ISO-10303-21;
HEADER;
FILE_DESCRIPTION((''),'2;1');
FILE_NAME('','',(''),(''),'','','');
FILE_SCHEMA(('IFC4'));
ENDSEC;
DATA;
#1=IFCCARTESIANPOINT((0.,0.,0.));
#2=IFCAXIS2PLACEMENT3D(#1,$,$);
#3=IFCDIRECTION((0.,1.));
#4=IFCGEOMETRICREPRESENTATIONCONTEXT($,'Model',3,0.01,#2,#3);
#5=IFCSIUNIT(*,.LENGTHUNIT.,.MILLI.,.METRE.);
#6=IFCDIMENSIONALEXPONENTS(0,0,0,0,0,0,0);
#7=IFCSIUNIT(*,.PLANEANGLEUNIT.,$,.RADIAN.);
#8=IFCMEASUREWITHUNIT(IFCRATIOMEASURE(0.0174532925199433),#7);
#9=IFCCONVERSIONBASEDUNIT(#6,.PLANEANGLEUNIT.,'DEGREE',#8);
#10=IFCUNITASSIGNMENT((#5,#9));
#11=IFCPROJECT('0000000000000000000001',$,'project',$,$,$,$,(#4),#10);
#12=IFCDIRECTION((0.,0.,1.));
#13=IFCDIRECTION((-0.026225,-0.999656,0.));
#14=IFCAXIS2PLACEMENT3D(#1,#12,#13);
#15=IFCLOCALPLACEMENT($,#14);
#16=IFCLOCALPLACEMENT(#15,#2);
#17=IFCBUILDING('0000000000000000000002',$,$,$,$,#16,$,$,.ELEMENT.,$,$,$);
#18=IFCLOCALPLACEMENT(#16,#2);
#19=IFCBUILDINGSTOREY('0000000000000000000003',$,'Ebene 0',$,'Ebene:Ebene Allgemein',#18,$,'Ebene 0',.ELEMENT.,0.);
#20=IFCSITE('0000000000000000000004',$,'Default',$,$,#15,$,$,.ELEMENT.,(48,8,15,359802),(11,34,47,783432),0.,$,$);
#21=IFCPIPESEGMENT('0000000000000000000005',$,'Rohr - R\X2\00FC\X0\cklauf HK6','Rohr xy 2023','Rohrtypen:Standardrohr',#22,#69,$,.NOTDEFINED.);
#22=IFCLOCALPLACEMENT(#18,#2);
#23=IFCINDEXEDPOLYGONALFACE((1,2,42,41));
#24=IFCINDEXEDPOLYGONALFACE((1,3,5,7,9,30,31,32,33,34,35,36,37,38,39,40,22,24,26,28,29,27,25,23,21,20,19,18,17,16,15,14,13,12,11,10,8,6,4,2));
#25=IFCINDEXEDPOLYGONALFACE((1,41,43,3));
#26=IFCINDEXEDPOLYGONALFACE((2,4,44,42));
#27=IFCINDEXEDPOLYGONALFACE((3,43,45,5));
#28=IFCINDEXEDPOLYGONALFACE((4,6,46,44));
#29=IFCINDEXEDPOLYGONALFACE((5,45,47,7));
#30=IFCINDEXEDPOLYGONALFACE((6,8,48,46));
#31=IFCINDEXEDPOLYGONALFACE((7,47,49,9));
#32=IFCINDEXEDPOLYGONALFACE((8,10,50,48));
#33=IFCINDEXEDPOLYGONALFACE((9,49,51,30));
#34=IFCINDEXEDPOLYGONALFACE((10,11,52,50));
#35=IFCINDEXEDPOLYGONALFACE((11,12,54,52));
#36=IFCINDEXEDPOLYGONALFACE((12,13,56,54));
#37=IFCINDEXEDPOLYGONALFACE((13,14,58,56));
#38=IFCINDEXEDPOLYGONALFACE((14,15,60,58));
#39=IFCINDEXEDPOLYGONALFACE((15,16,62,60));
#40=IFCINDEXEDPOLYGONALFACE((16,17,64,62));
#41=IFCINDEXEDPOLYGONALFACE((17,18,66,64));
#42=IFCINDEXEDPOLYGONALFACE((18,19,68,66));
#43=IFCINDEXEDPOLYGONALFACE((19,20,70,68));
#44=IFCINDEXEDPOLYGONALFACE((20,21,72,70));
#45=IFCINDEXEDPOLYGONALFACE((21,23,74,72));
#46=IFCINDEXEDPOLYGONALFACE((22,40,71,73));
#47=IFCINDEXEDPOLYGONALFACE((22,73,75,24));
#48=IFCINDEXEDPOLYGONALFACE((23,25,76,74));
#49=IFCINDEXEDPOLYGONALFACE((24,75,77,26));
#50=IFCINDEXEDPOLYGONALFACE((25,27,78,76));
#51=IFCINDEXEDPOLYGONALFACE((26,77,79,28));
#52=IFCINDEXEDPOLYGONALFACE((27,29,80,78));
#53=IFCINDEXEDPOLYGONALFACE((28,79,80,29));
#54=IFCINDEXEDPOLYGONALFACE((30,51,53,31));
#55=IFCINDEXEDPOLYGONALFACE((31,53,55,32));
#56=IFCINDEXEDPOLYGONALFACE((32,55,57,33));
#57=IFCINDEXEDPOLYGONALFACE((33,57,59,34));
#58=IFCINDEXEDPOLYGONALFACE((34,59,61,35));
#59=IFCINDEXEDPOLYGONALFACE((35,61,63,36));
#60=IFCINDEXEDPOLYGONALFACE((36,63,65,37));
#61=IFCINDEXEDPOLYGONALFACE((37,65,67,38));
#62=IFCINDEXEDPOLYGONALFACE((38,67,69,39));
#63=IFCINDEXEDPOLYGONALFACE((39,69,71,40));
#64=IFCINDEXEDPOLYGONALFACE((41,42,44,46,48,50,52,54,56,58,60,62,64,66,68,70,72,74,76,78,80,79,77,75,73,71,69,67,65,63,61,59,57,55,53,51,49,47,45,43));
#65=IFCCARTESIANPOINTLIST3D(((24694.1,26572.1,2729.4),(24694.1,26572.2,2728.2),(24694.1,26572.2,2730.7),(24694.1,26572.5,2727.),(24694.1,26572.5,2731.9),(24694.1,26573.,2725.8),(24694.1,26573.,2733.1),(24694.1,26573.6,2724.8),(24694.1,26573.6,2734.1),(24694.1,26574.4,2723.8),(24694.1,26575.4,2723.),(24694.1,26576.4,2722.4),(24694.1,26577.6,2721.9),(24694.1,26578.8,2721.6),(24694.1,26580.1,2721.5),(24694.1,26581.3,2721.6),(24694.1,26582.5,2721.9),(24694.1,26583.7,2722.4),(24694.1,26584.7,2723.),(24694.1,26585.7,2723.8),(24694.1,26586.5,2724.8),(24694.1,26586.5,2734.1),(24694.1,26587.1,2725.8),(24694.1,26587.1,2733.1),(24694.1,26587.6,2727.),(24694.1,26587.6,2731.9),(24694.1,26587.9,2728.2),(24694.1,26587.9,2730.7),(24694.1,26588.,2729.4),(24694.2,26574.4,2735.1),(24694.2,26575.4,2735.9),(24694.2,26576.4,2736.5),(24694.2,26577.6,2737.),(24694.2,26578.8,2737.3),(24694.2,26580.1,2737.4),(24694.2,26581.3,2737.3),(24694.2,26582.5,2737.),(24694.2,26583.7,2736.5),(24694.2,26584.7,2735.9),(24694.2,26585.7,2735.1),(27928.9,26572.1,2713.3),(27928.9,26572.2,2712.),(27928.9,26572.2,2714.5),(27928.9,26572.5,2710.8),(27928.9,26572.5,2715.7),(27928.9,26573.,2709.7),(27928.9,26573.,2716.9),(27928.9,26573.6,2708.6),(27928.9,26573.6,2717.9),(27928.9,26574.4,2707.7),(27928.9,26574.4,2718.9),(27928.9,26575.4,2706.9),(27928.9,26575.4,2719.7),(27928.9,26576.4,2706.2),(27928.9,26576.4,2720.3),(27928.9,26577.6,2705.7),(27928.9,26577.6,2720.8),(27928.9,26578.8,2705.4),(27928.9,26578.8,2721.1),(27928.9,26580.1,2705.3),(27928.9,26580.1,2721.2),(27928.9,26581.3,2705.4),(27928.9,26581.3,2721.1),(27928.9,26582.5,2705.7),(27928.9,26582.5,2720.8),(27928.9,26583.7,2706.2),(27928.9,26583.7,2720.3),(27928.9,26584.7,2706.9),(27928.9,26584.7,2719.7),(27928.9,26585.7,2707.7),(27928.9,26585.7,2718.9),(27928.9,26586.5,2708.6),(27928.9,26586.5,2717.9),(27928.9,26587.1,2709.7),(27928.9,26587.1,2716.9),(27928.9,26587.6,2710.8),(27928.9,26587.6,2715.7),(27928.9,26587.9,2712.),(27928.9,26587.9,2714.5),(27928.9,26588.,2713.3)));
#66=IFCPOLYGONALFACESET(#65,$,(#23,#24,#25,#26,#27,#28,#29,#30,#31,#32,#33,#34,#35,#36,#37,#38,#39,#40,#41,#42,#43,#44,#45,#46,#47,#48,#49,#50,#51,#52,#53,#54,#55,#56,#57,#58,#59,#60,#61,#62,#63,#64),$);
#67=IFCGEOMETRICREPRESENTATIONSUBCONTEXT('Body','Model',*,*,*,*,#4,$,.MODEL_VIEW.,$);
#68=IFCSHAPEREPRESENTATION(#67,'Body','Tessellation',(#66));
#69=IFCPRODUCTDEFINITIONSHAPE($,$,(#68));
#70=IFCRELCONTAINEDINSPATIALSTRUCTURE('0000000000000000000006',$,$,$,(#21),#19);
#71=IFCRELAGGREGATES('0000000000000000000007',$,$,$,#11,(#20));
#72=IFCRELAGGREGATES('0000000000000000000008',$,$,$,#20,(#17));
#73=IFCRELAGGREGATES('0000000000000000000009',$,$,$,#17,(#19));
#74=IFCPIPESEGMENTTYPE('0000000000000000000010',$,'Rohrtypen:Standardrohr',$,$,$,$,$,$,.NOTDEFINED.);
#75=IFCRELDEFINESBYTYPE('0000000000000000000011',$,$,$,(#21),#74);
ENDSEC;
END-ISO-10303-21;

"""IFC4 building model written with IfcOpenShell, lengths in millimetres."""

from ifc_helpers import new_model, entity, si_unit, converted_unit, direction, frame, origin, place, context, subcontext, project, spatial, indexed_curve, outline, extrude, type_object, element, save


model = new_model("IFC4")

# Units and contexts
model_context = context("Model", 3, precision=0.01, world=origin(), true_north=direction((0.0, 1.0)))
body_context = subcontext(model_context, "Body", "Model", "MODEL_VIEW")
ifc_project = project(units=[si_unit("LENGTHUNIT", "METRE", prefix="MILLI"), converted_unit("PLANEANGLEUNIT", "DEGREE", entity("IfcRatioMeasure", 0.0174532925199433), si_unit("PLANEANGLEUNIT", "RADIAN"), dimensions=[0, 0, 0, 0, 0, 0, 0])], contexts=[model_context])

# Site, building, storey
site_placement = place(None, frame((0.0, 0.0, 0.0), z_axis=(0.0, 0.0, 1.0), x_axis=(-0.026225, -0.999656, 0.0)))
site = spatial("IfcSite", under=ifc_project, at=site_placement, Name="Default", CompositionType="ELEMENT", RefLatitude=(48, 8, 15, 359802), RefLongitude=(11, 34, 47, 783432), RefElevation=0.0)
building_placement = place(site_placement, origin())
building = spatial("IfcBuilding", under=site, at=building_placement, CompositionType="ELEMENT")
storey_placement = place(building_placement, origin())
storey = spatial("IfcBuildingStorey", under=building, at=storey_placement, Name="Ebene 0", ObjectType="Ebene:Ebene Allgemein", LongName="Ebene 0", CompositionType="ELEMENT", Elevation=0.0)

# Pipe segment
pipe_segment_type = type_object("IfcPipeSegmentType", Name="Rohrtypen:Standardrohr", PredefinedType="NOTDEFINED")
pipe_segment_1_placement = place(storey_placement, origin())
element("IfcPipeSegment", 1, at=pipe_segment_1_placement, inside=storey, type_object=pipe_segment_type, Name="Rohr - Rücklauf HK6", Description="Rohr xy 2023", ObjectType="Rohrtypen:Standardrohr", PredefinedType="NOTDEFINED", context=body_context, shape_type="SweptSolid", body=[
    extrude(outline(indexed_curve([(7.9, 0.0), (7.8, 1.2), (7.6, 2.5), (7.1, 3.6), (6.4, 4.7), (5.6, 5.6), (4.7, 6.4), (3.6, 7.1), (2.5, 7.6), (1.2, 7.8), (0.0, 7.9), (-1.2, 7.8), (-2.5, 7.6), (-3.6, 7.1), (-4.7, 6.4), (-5.6, 5.6), (-6.4, 4.7), (-7.1, 3.6), (-7.6, 2.5), (-7.8, 1.2), (-7.9, 0.0), (-7.8, -1.2), (-7.6, -2.5), (-7.1, -3.6), (-6.4, -4.7), (-5.6, -5.6), (-4.7, -6.4), (-3.6, -7.1), (-2.5, -7.6), (-1.2, -7.8), (0.0, -7.9), (1.2, -7.8), (2.5, -7.6), (3.6, -7.1), (4.7, -6.4), (5.6, -5.6), (6.4, -4.7), (7.1, -3.6), (7.6, -2.5), (7.8, -1.2), (7.9, 0.0)], self_intersect=False)), frame((27928.9, 26580.1, 2713.3), z_axis=(-0.999988, 0.0, 0.005), x_axis=(0.0, 1.0, 0.0)), (0.0, 0.0, 1.0), 3234.8),
])

save(model, "model.ifc")
